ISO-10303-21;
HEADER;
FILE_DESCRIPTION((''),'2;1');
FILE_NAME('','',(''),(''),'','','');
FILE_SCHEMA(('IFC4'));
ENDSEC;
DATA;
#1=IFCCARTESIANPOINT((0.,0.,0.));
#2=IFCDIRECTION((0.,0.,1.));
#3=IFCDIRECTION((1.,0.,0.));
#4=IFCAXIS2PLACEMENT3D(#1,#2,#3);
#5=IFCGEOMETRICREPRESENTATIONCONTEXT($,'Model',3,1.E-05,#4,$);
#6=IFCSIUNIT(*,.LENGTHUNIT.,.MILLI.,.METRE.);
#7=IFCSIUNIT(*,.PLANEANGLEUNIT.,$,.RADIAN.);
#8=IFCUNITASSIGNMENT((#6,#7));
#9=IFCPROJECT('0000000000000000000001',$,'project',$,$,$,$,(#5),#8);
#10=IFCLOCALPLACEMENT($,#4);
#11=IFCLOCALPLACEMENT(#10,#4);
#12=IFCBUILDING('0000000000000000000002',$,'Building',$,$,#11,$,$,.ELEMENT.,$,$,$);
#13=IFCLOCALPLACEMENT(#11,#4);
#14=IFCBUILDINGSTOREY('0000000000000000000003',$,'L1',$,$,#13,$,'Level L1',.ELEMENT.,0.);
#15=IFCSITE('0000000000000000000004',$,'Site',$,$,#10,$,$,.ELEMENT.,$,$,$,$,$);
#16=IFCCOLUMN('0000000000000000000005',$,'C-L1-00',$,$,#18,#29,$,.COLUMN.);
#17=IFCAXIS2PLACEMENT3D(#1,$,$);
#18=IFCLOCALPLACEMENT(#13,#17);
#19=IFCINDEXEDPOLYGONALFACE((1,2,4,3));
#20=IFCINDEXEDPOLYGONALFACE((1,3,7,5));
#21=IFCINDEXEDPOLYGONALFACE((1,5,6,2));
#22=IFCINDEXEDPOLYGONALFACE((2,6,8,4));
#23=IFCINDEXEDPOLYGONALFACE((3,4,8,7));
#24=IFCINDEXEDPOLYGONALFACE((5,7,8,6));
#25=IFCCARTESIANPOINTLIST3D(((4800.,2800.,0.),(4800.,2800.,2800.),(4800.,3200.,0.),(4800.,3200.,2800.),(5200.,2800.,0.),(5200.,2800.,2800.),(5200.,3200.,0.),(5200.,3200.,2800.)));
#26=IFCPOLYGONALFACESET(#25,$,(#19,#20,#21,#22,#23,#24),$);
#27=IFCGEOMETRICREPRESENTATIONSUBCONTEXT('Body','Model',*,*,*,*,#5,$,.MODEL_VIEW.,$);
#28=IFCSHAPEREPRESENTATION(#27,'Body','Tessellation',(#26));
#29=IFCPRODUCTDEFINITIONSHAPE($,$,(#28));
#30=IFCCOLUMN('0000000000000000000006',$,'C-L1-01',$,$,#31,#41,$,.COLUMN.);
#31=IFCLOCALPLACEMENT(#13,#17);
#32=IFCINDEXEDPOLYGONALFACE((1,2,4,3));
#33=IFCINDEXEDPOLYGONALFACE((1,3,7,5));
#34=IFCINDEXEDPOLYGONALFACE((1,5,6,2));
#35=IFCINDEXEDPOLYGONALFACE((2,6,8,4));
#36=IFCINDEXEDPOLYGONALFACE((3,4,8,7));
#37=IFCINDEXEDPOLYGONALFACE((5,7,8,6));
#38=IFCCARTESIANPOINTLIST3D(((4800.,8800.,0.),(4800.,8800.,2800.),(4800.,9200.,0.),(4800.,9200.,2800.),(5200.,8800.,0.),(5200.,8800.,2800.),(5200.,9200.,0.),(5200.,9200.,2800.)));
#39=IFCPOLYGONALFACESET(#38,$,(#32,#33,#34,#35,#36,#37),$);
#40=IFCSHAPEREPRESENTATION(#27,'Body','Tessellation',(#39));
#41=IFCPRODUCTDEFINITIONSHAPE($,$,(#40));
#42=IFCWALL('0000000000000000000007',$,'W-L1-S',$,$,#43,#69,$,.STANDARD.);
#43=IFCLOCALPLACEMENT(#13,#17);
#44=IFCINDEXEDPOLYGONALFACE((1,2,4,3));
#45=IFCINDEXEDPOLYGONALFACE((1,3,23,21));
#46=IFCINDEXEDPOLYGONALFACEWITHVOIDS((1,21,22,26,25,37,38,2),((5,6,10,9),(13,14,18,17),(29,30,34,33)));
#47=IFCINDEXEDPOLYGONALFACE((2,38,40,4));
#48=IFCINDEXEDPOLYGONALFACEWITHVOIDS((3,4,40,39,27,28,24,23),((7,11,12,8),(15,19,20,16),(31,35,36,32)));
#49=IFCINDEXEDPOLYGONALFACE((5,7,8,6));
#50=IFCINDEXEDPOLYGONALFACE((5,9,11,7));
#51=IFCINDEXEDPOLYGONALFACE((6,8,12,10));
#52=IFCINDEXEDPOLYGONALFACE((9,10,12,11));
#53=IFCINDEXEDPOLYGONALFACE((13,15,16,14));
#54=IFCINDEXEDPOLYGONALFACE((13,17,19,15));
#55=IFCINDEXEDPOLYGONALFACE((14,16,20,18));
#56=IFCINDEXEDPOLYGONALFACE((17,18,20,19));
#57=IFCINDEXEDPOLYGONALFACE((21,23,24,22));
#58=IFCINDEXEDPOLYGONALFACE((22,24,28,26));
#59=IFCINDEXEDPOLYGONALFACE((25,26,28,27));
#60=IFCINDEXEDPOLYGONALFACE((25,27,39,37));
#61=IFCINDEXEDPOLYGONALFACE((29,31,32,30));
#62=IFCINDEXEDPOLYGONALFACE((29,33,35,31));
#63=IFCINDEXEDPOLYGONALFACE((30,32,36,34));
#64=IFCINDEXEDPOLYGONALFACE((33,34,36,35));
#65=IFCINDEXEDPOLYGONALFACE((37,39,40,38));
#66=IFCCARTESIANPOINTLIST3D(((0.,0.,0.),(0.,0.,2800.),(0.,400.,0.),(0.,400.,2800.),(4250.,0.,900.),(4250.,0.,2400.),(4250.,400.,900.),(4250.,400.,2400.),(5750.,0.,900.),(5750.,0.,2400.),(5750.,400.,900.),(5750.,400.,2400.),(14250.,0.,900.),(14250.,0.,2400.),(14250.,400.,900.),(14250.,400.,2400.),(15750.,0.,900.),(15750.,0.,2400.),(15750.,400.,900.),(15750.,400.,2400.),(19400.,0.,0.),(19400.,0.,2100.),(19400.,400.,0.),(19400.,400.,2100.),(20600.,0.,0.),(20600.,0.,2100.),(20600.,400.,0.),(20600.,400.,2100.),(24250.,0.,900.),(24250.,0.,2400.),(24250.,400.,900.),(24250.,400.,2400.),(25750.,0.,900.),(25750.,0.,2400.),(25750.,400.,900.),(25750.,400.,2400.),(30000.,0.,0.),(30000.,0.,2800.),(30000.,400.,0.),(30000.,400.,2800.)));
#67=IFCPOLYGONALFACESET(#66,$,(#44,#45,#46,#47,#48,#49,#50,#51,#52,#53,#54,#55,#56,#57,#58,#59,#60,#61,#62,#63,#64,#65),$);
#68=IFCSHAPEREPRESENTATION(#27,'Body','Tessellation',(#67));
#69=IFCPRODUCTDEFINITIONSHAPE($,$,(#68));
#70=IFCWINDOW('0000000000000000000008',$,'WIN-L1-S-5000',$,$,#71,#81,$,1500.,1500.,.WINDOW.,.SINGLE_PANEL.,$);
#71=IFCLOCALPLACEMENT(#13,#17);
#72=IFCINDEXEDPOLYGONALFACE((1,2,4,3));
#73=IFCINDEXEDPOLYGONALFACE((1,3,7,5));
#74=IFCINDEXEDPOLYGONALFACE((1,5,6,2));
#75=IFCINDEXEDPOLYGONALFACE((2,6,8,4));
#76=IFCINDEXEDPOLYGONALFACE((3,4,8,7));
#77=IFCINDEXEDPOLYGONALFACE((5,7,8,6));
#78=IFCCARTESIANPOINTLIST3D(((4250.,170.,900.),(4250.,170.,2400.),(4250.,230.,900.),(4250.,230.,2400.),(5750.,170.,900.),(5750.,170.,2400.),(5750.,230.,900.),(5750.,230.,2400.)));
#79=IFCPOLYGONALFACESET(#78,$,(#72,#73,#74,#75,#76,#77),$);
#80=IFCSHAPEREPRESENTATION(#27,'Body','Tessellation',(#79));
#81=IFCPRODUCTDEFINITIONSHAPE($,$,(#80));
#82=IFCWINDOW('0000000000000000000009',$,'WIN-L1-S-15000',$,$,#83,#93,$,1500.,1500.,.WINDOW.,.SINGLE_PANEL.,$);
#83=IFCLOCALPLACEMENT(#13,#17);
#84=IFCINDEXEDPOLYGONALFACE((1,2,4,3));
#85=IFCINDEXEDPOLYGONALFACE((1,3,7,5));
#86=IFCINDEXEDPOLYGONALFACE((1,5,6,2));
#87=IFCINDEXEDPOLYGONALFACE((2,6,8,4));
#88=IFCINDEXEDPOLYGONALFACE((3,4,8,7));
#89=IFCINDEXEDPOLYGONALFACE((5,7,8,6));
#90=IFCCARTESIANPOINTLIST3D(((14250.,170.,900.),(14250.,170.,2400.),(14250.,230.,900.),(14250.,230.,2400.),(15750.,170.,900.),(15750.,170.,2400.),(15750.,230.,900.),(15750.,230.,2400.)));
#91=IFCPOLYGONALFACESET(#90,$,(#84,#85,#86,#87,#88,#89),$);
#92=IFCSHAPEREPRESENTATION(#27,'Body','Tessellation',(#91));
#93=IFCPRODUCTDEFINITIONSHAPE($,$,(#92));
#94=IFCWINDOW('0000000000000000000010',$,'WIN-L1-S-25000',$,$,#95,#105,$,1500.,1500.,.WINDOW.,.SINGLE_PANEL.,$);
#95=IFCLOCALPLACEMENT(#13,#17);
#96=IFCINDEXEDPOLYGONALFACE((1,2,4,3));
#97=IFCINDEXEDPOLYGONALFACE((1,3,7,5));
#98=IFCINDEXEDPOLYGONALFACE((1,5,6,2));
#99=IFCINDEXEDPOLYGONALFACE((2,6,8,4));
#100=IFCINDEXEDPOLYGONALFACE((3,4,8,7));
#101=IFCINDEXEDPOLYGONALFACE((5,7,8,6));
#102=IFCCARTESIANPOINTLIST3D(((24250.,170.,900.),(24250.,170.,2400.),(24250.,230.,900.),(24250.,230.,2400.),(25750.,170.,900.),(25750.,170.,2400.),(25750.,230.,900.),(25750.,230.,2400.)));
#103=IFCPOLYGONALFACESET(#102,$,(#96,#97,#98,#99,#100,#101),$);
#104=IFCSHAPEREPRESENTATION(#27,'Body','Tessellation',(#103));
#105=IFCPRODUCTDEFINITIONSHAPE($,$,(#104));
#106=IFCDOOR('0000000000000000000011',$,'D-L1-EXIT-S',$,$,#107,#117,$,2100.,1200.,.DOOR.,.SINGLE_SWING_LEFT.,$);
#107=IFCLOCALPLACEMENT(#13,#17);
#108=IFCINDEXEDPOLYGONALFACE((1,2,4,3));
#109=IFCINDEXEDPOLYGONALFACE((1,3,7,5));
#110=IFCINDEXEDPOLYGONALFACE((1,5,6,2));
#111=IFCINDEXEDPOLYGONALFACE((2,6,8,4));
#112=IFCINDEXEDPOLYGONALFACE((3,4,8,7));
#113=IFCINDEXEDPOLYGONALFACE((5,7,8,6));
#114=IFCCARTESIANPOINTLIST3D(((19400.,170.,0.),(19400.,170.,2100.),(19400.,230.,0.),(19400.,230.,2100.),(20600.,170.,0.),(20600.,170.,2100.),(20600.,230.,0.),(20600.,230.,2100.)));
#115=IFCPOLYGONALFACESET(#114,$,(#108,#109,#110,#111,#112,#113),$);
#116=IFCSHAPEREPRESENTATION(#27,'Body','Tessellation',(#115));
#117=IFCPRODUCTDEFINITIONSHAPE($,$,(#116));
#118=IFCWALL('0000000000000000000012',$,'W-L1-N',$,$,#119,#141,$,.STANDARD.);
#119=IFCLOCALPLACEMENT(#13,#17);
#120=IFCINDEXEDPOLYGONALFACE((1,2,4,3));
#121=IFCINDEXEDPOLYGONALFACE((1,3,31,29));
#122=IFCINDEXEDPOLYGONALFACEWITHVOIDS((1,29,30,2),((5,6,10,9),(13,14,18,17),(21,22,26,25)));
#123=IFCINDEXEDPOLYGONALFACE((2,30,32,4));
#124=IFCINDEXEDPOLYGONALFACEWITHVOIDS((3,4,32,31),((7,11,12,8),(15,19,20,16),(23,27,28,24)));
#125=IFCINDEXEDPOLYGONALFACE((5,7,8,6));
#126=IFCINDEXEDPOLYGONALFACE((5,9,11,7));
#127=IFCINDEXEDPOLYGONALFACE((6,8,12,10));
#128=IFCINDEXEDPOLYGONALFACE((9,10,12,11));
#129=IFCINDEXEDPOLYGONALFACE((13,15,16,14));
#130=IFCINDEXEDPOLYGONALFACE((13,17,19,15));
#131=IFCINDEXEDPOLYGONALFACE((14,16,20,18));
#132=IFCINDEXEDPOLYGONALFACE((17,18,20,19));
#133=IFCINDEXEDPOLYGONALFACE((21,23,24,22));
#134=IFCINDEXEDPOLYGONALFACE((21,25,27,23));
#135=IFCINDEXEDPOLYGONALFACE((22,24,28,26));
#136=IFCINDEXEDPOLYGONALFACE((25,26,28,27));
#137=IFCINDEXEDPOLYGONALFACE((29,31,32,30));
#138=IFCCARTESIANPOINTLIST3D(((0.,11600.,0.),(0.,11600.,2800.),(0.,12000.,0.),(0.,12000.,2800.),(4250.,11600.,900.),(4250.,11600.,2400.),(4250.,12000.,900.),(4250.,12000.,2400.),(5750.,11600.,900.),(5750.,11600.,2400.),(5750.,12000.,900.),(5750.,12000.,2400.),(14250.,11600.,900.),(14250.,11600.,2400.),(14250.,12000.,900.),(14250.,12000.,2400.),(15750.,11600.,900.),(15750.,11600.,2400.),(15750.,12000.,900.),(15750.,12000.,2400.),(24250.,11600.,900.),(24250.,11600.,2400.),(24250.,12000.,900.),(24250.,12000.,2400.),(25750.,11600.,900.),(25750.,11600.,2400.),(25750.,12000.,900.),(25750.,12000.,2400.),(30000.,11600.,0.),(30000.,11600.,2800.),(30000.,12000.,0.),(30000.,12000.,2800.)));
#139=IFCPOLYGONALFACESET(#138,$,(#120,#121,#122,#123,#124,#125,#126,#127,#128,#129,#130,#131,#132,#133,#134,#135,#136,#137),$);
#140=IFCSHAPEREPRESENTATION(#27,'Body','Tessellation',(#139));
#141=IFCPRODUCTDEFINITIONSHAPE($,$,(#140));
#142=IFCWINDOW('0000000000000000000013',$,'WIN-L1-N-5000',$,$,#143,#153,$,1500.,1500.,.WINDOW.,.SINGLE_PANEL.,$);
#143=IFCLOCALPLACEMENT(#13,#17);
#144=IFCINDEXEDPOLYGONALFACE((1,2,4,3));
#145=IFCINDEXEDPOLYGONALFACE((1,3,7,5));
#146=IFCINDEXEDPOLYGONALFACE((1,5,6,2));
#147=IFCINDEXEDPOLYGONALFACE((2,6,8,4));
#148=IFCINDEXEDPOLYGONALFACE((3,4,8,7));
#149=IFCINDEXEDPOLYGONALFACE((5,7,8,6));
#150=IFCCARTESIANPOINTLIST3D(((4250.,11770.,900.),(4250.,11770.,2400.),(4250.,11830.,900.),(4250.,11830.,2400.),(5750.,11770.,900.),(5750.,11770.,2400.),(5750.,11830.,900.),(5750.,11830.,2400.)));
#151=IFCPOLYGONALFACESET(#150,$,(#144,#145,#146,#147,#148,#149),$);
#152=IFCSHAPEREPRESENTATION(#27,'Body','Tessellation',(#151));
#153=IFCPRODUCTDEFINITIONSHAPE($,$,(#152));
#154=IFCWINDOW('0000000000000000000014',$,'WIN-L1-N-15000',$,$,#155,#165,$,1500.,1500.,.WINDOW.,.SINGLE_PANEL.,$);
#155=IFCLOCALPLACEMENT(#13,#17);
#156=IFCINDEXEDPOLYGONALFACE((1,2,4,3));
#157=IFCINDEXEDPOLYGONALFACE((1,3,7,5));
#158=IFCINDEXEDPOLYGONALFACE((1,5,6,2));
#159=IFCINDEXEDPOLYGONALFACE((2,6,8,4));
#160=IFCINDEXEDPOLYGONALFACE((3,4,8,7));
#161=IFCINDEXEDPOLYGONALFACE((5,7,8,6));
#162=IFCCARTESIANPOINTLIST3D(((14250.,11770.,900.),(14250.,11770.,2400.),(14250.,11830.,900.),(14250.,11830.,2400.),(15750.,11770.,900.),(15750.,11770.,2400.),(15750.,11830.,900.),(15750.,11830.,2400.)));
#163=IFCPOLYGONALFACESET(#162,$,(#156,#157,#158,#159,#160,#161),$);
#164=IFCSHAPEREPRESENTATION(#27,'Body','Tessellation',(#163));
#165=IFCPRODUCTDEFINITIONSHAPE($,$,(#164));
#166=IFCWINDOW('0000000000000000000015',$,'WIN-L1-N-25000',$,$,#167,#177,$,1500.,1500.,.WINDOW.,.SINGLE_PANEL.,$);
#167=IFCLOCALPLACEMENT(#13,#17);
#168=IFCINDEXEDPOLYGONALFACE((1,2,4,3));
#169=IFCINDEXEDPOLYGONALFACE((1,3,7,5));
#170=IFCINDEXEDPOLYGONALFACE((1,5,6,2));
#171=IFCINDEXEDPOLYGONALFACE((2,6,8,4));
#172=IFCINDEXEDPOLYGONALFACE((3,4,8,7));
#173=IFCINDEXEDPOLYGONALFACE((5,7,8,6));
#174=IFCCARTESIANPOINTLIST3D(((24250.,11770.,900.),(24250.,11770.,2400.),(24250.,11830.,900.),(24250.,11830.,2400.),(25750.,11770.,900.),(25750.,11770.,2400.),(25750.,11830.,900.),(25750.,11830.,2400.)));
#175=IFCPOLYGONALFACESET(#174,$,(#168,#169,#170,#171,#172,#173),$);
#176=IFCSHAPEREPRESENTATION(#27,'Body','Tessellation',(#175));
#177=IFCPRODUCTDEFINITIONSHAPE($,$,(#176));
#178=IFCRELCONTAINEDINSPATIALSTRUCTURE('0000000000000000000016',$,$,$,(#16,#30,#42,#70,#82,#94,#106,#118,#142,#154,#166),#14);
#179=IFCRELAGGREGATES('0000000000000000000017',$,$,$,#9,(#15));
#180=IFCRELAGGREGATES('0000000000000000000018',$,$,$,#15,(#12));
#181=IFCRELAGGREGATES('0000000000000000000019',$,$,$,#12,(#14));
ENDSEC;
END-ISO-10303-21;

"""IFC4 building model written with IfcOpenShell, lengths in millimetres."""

from ifc_helpers import new_model, si_unit, frame, origin_with_axes, origin_2d, place, context, subcontext, project, spatial, rectangle, extrude, element, fill, save


model = new_model("IFC4")

# Units and contexts
model_context = context("Model", 3, precision=1e-05, world=origin_with_axes())
body_context = subcontext(model_context, "Body", "Model", "MODEL_VIEW")
ifc_project = project(units=[si_unit("LENGTHUNIT", "METRE", prefix="MILLI"), si_unit("PLANEANGLEUNIT", "RADIAN")], contexts=[model_context])

# Site, building, storey
site_placement = place(None, origin_with_axes())
site = spatial("IfcSite", under=ifc_project, at=site_placement, Name="Site", CompositionType="ELEMENT")
building_placement = place(site_placement, origin_with_axes())
building = spatial("IfcBuilding", under=site, at=building_placement, Name="Building", CompositionType="ELEMENT")
storey_placement = place(building_placement, origin_with_axes())
storey = spatial("IfcBuildingStorey", under=building, at=storey_placement, Name="L1", LongName="Level L1", CompositionType="ELEMENT", Elevation=0.0)

# Columns
for number, where, z_axis, x_axis, name in (
    (1, (5000.0, 3000.0, 0.0), (0.0, 0.0, 1.0), (1.0, 0.0, 0.0), "C-L1-00"),
    (2, (5000.0, 9000.0, 0.0), (0.0, 0.0, 1.0), (1.0, 0.0, 0.0), "C-L1-01"),
):
    element("IfcColumn", number, at=place(storey_placement, frame(where, z_axis=z_axis, x_axis=x_axis)), inside=storey, Name=name, PredefinedType="COLUMN", context=body_context, shape_type="SweptSolid", body=[
        extrude(rectangle(XDim=400.0, YDim=400.0, at=origin_2d()), origin_with_axes(), (0.0, 0.0, 1.0), 2800.0),
    ])

# Wall, openings, windows, door
wall_1_placement = place(storey_placement, frame((15000.0, 200.0, 0.0), z_axis=(0.0, 0.0, 1.0), x_axis=(1.0, 0.0, 0.0)))
wall_1 = element("IfcWall", 3, at=wall_1_placement, inside=storey, Name="W-L1-S", PredefinedType="STANDARD", context=body_context, shape_type="SweptSolid", body=[
    extrude(rectangle(XDim=30000.0, YDim=400.0, at=origin_2d()), origin_with_axes(), (0.0, 0.0, 1.0), 2800.0),
])
opening_1_placement = place(wall_1_placement, frame((-10000.0, 0.0, 900.0), z_axis=(0.0, 0.0, 1.0), x_axis=(1.0, 0.0, 0.0)))
opening_1 = element("IfcOpeningElement", 4, at=opening_1_placement, cuts=wall_1, PredefinedType="OPENING", context=body_context, shape_type="SweptSolid", body=[
    extrude(rectangle(XDim=1500.0, YDim=500.0, at=origin_2d()), origin_with_axes(), (0.0, 0.0, 1.0), 1500.0),
])
opening_2_placement = place(wall_1_placement, frame((0.0, 0.0, 900.0), z_axis=(0.0, 0.0, 1.0), x_axis=(1.0, 0.0, 0.0)))
opening_2 = element("IfcOpeningElement", 5, at=opening_2_placement, cuts=wall_1, PredefinedType="OPENING", context=body_context, shape_type="SweptSolid", body=[
    extrude(rectangle(XDim=1500.0, YDim=500.0, at=origin_2d()), origin_with_axes(), (0.0, 0.0, 1.0), 1500.0),
])
opening_3_placement = place(wall_1_placement, frame((10000.0, 0.0, 900.0), z_axis=(0.0, 0.0, 1.0), x_axis=(1.0, 0.0, 0.0)))
opening_3 = element("IfcOpeningElement", 6, at=opening_3_placement, cuts=wall_1, PredefinedType="OPENING", context=body_context, shape_type="SweptSolid", body=[
    extrude(rectangle(XDim=1500.0, YDim=500.0, at=origin_2d()), origin_with_axes(), (0.0, 0.0, 1.0), 1500.0),
])
opening_4_placement = place(wall_1_placement, frame((5000.0, 0.0, 0.0), z_axis=(0.0, 0.0, 1.0), x_axis=(1.0, 0.0, 0.0)))
opening_4 = element("IfcOpeningElement", 7, at=opening_4_placement, cuts=wall_1, PredefinedType="OPENING", context=body_context, shape_type="SweptSolid", body=[
    extrude(rectangle(XDim=1200.0, YDim=500.0, at=origin_2d()), origin_with_axes(), (0.0, 0.0, 1.0), 2100.0),
])
window_1_placement = place(wall_1_placement, frame((-10000.0, 0.0, 900.0), z_axis=(0.0, 0.0, 1.0), x_axis=(1.0, 0.0, 0.0)))
window_1 = element("IfcWindow", 8, at=window_1_placement, inside=storey, Name="WIN-L1-S-5000", OverallHeight=1500.0, OverallWidth=1500.0, PartitioningType="SINGLE_PANEL", PredefinedType="WINDOW", context=body_context, shape_type="SweptSolid", body=[
    extrude(rectangle(XDim=1500.0, YDim=60.0, at=origin_2d()), origin_with_axes(), (0.0, 0.0, 1.0), 1500.0),
])
fill(opening_1, window_1)
window_2_placement = place(wall_1_placement, frame((0.0, 0.0, 900.0), z_axis=(0.0, 0.0, 1.0), x_axis=(1.0, 0.0, 0.0)))
window_2 = element("IfcWindow", 9, at=window_2_placement, inside=storey, Name="WIN-L1-S-15000", OverallHeight=1500.0, OverallWidth=1500.0, PartitioningType="SINGLE_PANEL", PredefinedType="WINDOW", context=body_context, shape_type="SweptSolid", body=[
    extrude(rectangle(XDim=1500.0, YDim=60.0, at=origin_2d()), origin_with_axes(), (0.0, 0.0, 1.0), 1500.0),
])
fill(opening_2, window_2)
window_3_placement = place(wall_1_placement, frame((10000.0, 0.0, 900.0), z_axis=(0.0, 0.0, 1.0), x_axis=(1.0, 0.0, 0.0)))
window_3 = element("IfcWindow", 10, at=window_3_placement, inside=storey, Name="WIN-L1-S-25000", OverallHeight=1500.0, OverallWidth=1500.0, PartitioningType="SINGLE_PANEL", PredefinedType="WINDOW", context=body_context, shape_type="SweptSolid", body=[
    extrude(rectangle(XDim=1500.0, YDim=60.0, at=origin_2d()), origin_with_axes(), (0.0, 0.0, 1.0), 1500.0),
])
fill(opening_3, window_3)
door_1_placement = place(wall_1_placement, frame((5000.0, 0.0, 0.0), z_axis=(0.0, 0.0, 1.0), x_axis=(1.0, 0.0, 0.0)))
door_1 = element("IfcDoor", 11, at=door_1_placement, inside=storey, Name="D-L1-EXIT-S", OperationType="SINGLE_SWING_LEFT", OverallHeight=2100.0, OverallWidth=1200.0, PredefinedType="DOOR", context=body_context, shape_type="SweptSolid", body=[
    extrude(rectangle(XDim=1200.0, YDim=60.0, at=origin_2d()), origin_with_axes(), (0.0, 0.0, 1.0), 2100.0),
])
fill(opening_4, door_1)

# Wall, openings, windows
wall_2_placement = place(storey_placement, frame((15000.0, 11800.0, 0.0), z_axis=(0.0, 0.0, 1.0), x_axis=(1.0, 0.0, 0.0)))
wall_2 = element("IfcWall", 12, at=wall_2_placement, inside=storey, Name="W-L1-N", PredefinedType="STANDARD", context=body_context, shape_type="SweptSolid", body=[
    extrude(rectangle(XDim=30000.0, YDim=400.0, at=origin_2d()), origin_with_axes(), (0.0, 0.0, 1.0), 2800.0),
])
opening_5_placement = place(wall_2_placement, frame((-10000.0, 0.0, 900.0), z_axis=(0.0, 0.0, 1.0), x_axis=(1.0, 0.0, 0.0)))
opening_5 = element("IfcOpeningElement", 13, at=opening_5_placement, cuts=wall_2, PredefinedType="OPENING", context=body_context, shape_type="SweptSolid", body=[
    extrude(rectangle(XDim=1500.0, YDim=500.0, at=origin_2d()), origin_with_axes(), (0.0, 0.0, 1.0), 1500.0),
])
opening_6_placement = place(wall_2_placement, frame((0.0, 0.0, 900.0), z_axis=(0.0, 0.0, 1.0), x_axis=(1.0, 0.0, 0.0)))
opening_6 = element("IfcOpeningElement", 14, at=opening_6_placement, cuts=wall_2, PredefinedType="OPENING", context=body_context, shape_type="SweptSolid", body=[
    extrude(rectangle(XDim=1500.0, YDim=500.0, at=origin_2d()), origin_with_axes(), (0.0, 0.0, 1.0), 1500.0),
])
opening_7_placement = place(wall_2_placement, frame((10000.0, 0.0, 900.0), z_axis=(0.0, 0.0, 1.0), x_axis=(1.0, 0.0, 0.0)))
opening_7 = element("IfcOpeningElement", 15, at=opening_7_placement, cuts=wall_2, PredefinedType="OPENING", context=body_context, shape_type="SweptSolid", body=[
    extrude(rectangle(XDim=1500.0, YDim=500.0, at=origin_2d()), origin_with_axes(), (0.0, 0.0, 1.0), 1500.0),
])
window_4_placement = place(wall_2_placement, frame((-10000.0, 0.0, 900.0), z_axis=(0.0, 0.0, 1.0), x_axis=(1.0, 0.0, 0.0)))
window_4 = element("IfcWindow", 16, at=window_4_placement, inside=storey, Name="WIN-L1-N-5000", OverallHeight=1500.0, OverallWidth=1500.0, PartitioningType="SINGLE_PANEL", PredefinedType="WINDOW", context=body_context, shape_type="SweptSolid", body=[
    extrude(rectangle(XDim=1500.0, YDim=60.0, at=origin_2d()), origin_with_axes(), (0.0, 0.0, 1.0), 1500.0),
])
fill(opening_5, window_4)
window_5_placement = place(wall_2_placement, frame((0.0, 0.0, 900.0), z_axis=(0.0, 0.0, 1.0), x_axis=(1.0, 0.0, 0.0)))
window_5 = element("IfcWindow", 17, at=window_5_placement, inside=storey, Name="WIN-L1-N-15000", OverallHeight=1500.0, OverallWidth=1500.0, PartitioningType="SINGLE_PANEL", PredefinedType="WINDOW", context=body_context, shape_type="SweptSolid", body=[
    extrude(rectangle(XDim=1500.0, YDim=60.0, at=origin_2d()), origin_with_axes(), (0.0, 0.0, 1.0), 1500.0),
])
fill(opening_6, window_5)
window_6_placement = place(wall_2_placement, frame((10000.0, 0.0, 900.0), z_axis=(0.0, 0.0, 1.0), x_axis=(1.0, 0.0, 0.0)))
window_6 = element("IfcWindow", 18, at=window_6_placement, inside=storey, Name="WIN-L1-N-25000", OverallHeight=1500.0, OverallWidth=1500.0, PartitioningType="SINGLE_PANEL", PredefinedType="WINDOW", context=body_context, shape_type="SweptSolid", body=[
    extrude(rectangle(XDim=1500.0, YDim=60.0, at=origin_2d()), origin_with_axes(), (0.0, 0.0, 1.0), 1500.0),
])
fill(opening_7, window_6)

save(model, "model.ifc")
